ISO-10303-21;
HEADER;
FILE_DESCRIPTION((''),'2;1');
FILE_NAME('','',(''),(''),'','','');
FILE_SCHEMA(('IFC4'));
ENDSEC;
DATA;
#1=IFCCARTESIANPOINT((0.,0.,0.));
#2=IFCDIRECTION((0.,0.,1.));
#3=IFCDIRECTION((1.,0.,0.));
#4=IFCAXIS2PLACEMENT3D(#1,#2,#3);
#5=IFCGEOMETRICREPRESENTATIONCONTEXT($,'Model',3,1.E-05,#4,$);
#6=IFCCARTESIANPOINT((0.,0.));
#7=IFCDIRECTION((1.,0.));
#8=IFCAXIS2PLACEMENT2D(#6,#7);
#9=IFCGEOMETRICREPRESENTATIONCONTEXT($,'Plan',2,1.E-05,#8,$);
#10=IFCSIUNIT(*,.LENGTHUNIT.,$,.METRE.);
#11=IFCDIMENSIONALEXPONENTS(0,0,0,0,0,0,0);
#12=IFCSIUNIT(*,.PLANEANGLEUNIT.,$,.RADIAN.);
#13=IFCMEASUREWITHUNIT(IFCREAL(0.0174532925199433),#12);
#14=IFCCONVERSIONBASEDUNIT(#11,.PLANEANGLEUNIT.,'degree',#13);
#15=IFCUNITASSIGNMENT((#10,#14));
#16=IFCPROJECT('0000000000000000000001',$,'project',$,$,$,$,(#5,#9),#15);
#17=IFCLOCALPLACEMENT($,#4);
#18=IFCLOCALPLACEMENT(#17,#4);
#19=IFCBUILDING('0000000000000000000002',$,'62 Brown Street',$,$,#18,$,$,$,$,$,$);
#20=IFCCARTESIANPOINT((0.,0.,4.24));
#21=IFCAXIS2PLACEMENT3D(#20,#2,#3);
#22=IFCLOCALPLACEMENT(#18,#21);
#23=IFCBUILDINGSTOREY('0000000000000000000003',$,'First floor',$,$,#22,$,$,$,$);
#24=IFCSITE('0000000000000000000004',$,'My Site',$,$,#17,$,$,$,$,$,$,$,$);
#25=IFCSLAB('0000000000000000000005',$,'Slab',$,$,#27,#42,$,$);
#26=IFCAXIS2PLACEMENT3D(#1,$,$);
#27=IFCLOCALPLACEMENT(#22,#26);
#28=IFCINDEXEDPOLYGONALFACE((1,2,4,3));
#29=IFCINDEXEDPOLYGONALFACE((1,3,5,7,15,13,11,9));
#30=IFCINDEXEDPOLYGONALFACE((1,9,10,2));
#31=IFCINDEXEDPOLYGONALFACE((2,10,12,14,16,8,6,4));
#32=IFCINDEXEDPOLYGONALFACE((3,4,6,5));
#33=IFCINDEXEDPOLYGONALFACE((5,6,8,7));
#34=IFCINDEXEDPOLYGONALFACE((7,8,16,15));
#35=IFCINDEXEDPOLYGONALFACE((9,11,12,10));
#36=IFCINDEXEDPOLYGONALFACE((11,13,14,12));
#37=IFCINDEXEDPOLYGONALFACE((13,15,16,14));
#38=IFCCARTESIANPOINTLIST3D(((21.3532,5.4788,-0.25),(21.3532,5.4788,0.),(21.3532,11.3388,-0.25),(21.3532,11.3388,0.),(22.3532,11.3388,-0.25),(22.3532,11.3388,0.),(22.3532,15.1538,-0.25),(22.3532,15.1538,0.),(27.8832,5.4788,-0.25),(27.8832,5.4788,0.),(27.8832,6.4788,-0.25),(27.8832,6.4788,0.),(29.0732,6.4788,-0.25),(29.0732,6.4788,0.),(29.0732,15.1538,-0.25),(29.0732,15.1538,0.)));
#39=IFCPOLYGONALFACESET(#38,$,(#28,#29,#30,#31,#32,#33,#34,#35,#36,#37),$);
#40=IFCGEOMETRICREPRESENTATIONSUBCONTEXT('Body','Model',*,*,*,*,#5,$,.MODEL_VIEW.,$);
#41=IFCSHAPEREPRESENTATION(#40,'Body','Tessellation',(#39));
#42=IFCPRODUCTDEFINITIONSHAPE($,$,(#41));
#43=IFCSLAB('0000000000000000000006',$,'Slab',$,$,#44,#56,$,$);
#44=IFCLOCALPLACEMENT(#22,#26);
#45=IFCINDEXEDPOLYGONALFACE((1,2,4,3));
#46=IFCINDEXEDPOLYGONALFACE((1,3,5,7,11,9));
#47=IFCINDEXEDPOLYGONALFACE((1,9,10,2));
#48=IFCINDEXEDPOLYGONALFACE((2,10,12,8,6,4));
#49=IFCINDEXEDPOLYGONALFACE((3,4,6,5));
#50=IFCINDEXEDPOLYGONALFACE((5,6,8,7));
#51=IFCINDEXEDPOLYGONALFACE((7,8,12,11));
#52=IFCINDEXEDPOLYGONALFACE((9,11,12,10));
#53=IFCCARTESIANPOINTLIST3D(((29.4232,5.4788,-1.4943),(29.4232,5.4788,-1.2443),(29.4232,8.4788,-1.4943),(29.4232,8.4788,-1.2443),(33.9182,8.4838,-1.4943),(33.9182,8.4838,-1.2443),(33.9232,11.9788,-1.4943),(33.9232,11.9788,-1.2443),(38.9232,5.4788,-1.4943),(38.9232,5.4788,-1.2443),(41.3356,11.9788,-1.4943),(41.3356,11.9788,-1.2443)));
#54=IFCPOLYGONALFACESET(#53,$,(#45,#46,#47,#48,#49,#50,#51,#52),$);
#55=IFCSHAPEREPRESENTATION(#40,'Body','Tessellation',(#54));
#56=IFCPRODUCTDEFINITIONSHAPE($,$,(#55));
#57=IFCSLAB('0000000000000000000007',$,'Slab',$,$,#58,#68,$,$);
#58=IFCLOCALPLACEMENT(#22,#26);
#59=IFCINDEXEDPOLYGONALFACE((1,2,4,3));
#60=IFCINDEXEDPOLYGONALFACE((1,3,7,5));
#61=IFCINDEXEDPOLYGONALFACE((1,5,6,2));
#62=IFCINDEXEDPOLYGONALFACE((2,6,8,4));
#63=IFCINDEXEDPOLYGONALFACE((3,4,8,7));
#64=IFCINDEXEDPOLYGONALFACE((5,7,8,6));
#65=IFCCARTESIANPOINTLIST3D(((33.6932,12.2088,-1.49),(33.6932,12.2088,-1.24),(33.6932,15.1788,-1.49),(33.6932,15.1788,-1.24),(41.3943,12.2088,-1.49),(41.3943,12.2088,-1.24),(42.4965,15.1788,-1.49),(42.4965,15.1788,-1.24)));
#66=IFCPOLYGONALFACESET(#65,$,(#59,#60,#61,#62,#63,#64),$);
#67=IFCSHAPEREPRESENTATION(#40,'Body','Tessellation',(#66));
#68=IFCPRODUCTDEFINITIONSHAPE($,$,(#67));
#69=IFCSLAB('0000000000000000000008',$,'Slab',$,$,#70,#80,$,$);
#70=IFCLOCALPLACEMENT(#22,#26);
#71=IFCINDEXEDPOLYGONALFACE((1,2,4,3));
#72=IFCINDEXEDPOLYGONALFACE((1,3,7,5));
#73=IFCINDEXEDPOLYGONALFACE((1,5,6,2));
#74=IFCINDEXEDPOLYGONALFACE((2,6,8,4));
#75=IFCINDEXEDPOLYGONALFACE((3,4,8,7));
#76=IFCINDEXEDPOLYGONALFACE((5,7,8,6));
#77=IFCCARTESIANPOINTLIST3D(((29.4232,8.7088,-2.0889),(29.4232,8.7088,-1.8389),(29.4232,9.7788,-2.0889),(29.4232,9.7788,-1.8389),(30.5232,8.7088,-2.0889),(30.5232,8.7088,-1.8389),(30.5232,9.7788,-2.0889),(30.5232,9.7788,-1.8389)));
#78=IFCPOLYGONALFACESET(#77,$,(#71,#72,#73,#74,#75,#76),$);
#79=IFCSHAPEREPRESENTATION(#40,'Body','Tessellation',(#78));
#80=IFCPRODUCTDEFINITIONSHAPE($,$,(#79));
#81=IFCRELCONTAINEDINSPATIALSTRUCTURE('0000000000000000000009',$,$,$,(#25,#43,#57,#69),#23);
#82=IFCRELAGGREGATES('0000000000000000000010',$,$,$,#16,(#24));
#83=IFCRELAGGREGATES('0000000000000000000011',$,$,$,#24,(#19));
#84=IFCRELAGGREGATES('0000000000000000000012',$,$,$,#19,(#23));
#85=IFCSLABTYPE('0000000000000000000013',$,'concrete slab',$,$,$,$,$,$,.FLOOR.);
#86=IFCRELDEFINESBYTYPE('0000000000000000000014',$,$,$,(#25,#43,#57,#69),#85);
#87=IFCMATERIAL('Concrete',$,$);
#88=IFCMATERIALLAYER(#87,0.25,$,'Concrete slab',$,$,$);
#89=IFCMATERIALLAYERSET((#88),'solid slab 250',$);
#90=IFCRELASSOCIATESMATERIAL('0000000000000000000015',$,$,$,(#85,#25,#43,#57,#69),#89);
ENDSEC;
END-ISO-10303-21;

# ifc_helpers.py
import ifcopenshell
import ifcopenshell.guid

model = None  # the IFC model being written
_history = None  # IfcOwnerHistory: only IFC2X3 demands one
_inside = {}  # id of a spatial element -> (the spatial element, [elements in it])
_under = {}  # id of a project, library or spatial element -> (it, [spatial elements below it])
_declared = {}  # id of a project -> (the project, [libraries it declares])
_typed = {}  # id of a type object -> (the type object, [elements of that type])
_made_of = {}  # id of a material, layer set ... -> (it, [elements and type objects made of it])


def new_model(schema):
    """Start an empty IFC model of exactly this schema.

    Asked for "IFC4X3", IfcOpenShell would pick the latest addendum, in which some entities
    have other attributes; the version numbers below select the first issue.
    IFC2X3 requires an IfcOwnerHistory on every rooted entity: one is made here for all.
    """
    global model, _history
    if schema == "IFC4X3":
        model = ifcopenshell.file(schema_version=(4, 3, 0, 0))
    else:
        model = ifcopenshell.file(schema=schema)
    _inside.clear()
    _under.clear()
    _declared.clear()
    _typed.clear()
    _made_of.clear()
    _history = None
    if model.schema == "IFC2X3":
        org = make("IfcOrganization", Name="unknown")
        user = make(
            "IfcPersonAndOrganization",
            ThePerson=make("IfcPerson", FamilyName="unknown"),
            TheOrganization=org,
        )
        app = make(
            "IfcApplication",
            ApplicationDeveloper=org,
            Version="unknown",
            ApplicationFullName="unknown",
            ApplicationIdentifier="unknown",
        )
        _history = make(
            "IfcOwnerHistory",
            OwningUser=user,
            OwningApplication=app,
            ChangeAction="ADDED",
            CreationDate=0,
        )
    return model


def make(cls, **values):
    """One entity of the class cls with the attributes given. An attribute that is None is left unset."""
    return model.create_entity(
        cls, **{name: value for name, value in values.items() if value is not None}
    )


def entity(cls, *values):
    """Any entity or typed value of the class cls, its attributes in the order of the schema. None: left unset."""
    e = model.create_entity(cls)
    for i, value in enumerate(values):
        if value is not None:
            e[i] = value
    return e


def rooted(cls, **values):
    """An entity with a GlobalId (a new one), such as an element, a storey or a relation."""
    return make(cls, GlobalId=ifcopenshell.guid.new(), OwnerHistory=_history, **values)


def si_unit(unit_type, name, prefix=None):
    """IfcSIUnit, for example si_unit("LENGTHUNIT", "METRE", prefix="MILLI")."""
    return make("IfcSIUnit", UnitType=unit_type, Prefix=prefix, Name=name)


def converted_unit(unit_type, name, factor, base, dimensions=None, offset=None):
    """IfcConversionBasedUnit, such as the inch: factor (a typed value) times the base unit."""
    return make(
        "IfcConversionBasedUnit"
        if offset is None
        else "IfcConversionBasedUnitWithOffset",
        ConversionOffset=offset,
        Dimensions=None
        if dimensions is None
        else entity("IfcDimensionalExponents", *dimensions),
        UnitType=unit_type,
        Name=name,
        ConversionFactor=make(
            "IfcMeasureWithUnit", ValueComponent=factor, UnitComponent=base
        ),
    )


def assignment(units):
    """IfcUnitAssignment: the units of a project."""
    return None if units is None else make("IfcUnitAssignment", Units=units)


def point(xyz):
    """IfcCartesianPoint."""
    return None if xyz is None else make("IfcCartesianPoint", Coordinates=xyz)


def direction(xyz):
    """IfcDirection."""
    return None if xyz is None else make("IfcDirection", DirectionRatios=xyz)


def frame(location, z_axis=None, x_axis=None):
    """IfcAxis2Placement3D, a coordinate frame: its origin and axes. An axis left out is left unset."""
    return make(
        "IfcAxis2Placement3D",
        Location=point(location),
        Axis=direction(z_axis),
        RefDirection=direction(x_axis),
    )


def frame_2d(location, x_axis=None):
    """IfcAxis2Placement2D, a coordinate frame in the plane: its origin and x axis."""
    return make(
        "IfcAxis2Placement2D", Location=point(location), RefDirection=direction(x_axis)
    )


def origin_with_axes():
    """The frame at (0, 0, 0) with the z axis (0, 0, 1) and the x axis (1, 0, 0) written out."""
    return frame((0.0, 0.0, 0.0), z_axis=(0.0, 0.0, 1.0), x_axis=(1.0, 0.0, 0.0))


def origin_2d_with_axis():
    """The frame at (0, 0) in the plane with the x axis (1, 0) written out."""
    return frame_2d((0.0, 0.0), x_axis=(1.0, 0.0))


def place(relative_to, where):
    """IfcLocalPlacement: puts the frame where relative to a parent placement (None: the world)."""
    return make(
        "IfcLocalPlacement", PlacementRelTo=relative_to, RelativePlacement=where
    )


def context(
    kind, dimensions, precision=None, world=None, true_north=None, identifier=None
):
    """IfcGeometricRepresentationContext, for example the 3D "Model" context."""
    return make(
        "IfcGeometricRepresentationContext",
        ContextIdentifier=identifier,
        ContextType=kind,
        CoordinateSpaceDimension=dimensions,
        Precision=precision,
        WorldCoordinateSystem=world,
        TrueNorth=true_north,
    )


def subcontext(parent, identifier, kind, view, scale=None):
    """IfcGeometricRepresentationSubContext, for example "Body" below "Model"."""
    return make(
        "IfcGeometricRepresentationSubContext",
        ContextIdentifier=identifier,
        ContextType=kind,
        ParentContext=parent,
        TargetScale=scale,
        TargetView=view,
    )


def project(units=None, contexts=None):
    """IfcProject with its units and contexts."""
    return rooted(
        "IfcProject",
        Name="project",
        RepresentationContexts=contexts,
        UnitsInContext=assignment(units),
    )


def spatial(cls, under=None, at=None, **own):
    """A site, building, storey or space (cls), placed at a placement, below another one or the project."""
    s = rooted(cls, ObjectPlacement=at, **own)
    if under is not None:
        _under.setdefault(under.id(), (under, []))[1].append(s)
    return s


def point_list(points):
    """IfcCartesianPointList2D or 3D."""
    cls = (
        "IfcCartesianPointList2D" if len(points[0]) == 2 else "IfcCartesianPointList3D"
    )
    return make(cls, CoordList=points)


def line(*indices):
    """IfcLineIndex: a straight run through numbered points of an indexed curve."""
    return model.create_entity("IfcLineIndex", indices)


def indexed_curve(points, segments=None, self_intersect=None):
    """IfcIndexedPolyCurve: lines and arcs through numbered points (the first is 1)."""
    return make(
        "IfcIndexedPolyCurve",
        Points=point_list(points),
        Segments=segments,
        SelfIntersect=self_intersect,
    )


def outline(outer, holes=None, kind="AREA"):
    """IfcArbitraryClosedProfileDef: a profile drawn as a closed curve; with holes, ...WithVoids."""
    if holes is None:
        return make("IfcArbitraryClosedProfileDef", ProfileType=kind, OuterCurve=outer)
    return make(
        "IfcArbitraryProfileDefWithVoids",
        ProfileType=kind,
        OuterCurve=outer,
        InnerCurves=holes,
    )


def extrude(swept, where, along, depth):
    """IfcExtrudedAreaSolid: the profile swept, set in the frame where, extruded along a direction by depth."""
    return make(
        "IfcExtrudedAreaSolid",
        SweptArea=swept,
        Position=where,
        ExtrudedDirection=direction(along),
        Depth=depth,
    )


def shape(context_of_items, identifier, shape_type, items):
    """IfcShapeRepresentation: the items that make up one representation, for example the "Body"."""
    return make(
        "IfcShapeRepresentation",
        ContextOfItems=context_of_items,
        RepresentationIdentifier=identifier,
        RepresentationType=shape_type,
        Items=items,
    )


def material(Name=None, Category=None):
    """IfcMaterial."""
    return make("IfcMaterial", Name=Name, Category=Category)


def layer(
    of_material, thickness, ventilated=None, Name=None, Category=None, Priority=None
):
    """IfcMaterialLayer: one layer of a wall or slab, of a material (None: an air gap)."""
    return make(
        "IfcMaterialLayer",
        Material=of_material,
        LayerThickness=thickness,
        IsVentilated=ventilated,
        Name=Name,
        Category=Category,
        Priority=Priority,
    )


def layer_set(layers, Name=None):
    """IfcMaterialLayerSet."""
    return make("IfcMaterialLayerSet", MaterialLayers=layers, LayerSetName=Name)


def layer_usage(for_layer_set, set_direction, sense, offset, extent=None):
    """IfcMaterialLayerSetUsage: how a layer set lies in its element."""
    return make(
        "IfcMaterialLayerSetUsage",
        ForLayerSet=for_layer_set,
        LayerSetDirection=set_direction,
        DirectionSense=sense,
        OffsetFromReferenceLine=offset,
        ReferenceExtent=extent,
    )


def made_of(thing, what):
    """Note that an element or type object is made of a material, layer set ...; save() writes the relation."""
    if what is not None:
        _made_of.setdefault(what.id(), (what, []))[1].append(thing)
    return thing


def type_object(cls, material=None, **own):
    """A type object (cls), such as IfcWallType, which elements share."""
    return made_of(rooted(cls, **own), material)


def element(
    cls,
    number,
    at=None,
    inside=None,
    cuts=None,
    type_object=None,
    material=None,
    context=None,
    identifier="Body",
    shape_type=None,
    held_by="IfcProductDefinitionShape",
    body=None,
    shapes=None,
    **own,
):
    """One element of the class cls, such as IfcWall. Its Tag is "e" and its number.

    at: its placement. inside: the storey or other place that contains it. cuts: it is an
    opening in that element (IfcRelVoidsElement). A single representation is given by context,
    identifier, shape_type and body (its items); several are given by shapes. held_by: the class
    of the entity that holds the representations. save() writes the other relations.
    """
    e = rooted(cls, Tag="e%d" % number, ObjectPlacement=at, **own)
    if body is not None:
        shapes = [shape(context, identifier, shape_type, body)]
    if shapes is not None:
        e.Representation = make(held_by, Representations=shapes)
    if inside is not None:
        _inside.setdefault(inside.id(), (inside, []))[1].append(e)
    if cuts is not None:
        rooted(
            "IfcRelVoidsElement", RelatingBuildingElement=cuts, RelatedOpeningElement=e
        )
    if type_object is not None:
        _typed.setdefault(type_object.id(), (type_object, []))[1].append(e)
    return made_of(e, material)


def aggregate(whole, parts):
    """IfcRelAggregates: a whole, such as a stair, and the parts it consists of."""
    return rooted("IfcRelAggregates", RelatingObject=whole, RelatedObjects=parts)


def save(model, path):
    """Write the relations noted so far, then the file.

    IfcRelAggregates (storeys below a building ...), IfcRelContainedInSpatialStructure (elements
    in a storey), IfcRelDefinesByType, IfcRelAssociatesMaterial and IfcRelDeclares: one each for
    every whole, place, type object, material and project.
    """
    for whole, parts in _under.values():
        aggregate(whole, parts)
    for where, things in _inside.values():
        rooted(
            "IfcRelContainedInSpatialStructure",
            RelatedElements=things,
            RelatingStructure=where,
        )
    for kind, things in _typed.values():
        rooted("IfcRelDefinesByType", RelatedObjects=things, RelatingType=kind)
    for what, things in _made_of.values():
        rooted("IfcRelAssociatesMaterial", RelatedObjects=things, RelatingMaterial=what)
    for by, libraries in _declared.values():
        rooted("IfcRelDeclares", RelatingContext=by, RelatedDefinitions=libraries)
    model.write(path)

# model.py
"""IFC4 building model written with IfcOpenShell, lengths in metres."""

from ifc_helpers import new_model, entity, si_unit, converted_unit, frame, origin_with_axes, origin_2d_with_axis, place, context, subcontext, project, spatial, line, indexed_curve, outline, extrude, material, layer, layer_set, layer_usage, type_object, element, save


model = new_model("IFC4")

# Units and contexts
model_context = context("Model", 3, precision=1e-05, world=origin_with_axes())
plan_context = context("Plan", 2, precision=1e-05, world=origin_2d_with_axis())
body_context = subcontext(model_context, "Body", "Model", "MODEL_VIEW")
ifc_project = project(units=[si_unit("LENGTHUNIT", "METRE"), converted_unit("PLANEANGLEUNIT", "degree", entity("IfcReal", 0.0174532925199433), si_unit("PLANEANGLEUNIT", "RADIAN"), dimensions=[0, 0, 0, 0, 0, 0, 0])], contexts=[model_context, plan_context])

# Site, building, storey
site_placement = place(None, origin_with_axes())
site = spatial("IfcSite", under=ifc_project, at=site_placement, Name="My Site")
building_placement = place(site_placement, origin_with_axes())
building = spatial("IfcBuilding", under=site, at=building_placement, Name="62 Brown Street")
storey_placement = place(building_placement, frame((0.0, 0.0, 4.24), z_axis=(0.0, 0.0, 1.0), x_axis=(1.0, 0.0, 0.0)))
storey = spatial("IfcBuildingStorey", under=building, at=storey_placement, Name="First floor")

# Slabs
ifc_material = material(Name="Concrete")
ifc_layer = layer(ifc_material, 0.25, Name="Concrete slab")
ifc_layer_set = layer_set([ifc_layer], Name="solid slab 250")
ifc_layer_usage_1 = layer_usage(ifc_layer_set, "AXIS3", "POSITIVE", 0.0)
slab_type = type_object("IfcSlabType", Name="concrete slab", PredefinedType="FLOOR", material=ifc_layer_set)
slab_1_placement = place(storey_placement, frame((21.3532, 5.4788, -0.25), z_axis=(0.0, 0.0, 1.0), x_axis=(1.0, 0.0, 0.0)))
element("IfcSlab", 1, at=slab_1_placement, inside=storey, type_object=slab_type, material=ifc_layer_usage_1, Name="Slab", context=body_context, shape_type="SweptSolid", body=[
    extrude(outline(indexed_curve([(0.0, 0.0), (0.0, 5.86), (1.0, 5.86), (1.0, 9.675), (7.72, 9.675), (7.72, 1.0), (6.53, 1.0), (6.53, 0.0)], segments=[line(2, 1), line(1, 8), line(8, 7), line(7, 6), line(6, 5), line(5, 4), line(4, 3), line(3, 2)], self_intersect=False)), None, (0.0, 0.0, 1.0), 0.25),
])
ifc_layer_usage_2 = layer_usage(ifc_layer_set, "AXIS3", "POSITIVE", 0.0)
slab_2_placement = place(storey_placement, frame((29.4232, 5.4788, -1.4943), z_axis=(0.0, 0.0, 1.0), x_axis=(1.0, 0.0, 0.0)))
element("IfcSlab", 2, at=slab_2_placement, inside=storey, type_object=slab_type, material=ifc_layer_usage_2, Name="Slab", context=body_context, shape_type="SweptSolid", body=[
    extrude(outline(indexed_curve([(0.0, 0.0), (9.5, 0.0), (11.9124, 6.5), (0.0, 3.0), (4.5, 6.5), (4.495, 3.005)], segments=[line(1, 2), line(2, 3), line(3, 5), line(5, 6), line(6, 4), line(4, 1)], self_intersect=False)), None, (0.0, 0.0, 1.0), 0.25),
])
ifc_layer_usage_3 = layer_usage(ifc_layer_set, "AXIS3", "POSITIVE", 0.0)
slab_3_placement = place(storey_placement, frame((33.6932, 12.2088, -1.49), z_axis=(0.0, 0.0, 1.0), x_axis=(1.0, 0.0, 0.0)))
element("IfcSlab", 3, at=slab_3_placement, inside=storey, type_object=slab_type, material=ifc_layer_usage_3, Name="Slab", context=body_context, shape_type="SweptSolid", body=[
    extrude(outline(indexed_curve([(8.8033, 2.97), (7.7011, 0.0), (0.0, 0.0), (0.0, 2.97)], segments=[line(4, 1), line(1, 2), line(2, 3), line(3, 4)], self_intersect=False)), None, (0.0, 0.0, 1.0), 0.25),
])
ifc_layer_usage_4 = layer_usage(ifc_layer_set, "AXIS3", "POSITIVE", 0.0)
slab_4_placement = place(storey_placement, frame((29.4232, 8.7088, -2.0889), z_axis=(0.0, 0.0, 1.0), x_axis=(1.0, 0.0, 0.0)))
element("IfcSlab", 4, at=slab_4_placement, inside=storey, type_object=slab_type, material=ifc_layer_usage_4, Name="Slab", context=body_context, shape_type="SweptSolid", body=[
    extrude(outline(indexed_curve([(0.0, 0.0), (1.1, 0.0), (1.1, 1.07), (0.0, 1.07)], segments=[line(3, 2), line(2, 1), line(1, 4), line(4, 3)], self_intersect=False)), None, (0.0, 0.0, 1.0), 0.25),
])

save(model, "model.ifc")
